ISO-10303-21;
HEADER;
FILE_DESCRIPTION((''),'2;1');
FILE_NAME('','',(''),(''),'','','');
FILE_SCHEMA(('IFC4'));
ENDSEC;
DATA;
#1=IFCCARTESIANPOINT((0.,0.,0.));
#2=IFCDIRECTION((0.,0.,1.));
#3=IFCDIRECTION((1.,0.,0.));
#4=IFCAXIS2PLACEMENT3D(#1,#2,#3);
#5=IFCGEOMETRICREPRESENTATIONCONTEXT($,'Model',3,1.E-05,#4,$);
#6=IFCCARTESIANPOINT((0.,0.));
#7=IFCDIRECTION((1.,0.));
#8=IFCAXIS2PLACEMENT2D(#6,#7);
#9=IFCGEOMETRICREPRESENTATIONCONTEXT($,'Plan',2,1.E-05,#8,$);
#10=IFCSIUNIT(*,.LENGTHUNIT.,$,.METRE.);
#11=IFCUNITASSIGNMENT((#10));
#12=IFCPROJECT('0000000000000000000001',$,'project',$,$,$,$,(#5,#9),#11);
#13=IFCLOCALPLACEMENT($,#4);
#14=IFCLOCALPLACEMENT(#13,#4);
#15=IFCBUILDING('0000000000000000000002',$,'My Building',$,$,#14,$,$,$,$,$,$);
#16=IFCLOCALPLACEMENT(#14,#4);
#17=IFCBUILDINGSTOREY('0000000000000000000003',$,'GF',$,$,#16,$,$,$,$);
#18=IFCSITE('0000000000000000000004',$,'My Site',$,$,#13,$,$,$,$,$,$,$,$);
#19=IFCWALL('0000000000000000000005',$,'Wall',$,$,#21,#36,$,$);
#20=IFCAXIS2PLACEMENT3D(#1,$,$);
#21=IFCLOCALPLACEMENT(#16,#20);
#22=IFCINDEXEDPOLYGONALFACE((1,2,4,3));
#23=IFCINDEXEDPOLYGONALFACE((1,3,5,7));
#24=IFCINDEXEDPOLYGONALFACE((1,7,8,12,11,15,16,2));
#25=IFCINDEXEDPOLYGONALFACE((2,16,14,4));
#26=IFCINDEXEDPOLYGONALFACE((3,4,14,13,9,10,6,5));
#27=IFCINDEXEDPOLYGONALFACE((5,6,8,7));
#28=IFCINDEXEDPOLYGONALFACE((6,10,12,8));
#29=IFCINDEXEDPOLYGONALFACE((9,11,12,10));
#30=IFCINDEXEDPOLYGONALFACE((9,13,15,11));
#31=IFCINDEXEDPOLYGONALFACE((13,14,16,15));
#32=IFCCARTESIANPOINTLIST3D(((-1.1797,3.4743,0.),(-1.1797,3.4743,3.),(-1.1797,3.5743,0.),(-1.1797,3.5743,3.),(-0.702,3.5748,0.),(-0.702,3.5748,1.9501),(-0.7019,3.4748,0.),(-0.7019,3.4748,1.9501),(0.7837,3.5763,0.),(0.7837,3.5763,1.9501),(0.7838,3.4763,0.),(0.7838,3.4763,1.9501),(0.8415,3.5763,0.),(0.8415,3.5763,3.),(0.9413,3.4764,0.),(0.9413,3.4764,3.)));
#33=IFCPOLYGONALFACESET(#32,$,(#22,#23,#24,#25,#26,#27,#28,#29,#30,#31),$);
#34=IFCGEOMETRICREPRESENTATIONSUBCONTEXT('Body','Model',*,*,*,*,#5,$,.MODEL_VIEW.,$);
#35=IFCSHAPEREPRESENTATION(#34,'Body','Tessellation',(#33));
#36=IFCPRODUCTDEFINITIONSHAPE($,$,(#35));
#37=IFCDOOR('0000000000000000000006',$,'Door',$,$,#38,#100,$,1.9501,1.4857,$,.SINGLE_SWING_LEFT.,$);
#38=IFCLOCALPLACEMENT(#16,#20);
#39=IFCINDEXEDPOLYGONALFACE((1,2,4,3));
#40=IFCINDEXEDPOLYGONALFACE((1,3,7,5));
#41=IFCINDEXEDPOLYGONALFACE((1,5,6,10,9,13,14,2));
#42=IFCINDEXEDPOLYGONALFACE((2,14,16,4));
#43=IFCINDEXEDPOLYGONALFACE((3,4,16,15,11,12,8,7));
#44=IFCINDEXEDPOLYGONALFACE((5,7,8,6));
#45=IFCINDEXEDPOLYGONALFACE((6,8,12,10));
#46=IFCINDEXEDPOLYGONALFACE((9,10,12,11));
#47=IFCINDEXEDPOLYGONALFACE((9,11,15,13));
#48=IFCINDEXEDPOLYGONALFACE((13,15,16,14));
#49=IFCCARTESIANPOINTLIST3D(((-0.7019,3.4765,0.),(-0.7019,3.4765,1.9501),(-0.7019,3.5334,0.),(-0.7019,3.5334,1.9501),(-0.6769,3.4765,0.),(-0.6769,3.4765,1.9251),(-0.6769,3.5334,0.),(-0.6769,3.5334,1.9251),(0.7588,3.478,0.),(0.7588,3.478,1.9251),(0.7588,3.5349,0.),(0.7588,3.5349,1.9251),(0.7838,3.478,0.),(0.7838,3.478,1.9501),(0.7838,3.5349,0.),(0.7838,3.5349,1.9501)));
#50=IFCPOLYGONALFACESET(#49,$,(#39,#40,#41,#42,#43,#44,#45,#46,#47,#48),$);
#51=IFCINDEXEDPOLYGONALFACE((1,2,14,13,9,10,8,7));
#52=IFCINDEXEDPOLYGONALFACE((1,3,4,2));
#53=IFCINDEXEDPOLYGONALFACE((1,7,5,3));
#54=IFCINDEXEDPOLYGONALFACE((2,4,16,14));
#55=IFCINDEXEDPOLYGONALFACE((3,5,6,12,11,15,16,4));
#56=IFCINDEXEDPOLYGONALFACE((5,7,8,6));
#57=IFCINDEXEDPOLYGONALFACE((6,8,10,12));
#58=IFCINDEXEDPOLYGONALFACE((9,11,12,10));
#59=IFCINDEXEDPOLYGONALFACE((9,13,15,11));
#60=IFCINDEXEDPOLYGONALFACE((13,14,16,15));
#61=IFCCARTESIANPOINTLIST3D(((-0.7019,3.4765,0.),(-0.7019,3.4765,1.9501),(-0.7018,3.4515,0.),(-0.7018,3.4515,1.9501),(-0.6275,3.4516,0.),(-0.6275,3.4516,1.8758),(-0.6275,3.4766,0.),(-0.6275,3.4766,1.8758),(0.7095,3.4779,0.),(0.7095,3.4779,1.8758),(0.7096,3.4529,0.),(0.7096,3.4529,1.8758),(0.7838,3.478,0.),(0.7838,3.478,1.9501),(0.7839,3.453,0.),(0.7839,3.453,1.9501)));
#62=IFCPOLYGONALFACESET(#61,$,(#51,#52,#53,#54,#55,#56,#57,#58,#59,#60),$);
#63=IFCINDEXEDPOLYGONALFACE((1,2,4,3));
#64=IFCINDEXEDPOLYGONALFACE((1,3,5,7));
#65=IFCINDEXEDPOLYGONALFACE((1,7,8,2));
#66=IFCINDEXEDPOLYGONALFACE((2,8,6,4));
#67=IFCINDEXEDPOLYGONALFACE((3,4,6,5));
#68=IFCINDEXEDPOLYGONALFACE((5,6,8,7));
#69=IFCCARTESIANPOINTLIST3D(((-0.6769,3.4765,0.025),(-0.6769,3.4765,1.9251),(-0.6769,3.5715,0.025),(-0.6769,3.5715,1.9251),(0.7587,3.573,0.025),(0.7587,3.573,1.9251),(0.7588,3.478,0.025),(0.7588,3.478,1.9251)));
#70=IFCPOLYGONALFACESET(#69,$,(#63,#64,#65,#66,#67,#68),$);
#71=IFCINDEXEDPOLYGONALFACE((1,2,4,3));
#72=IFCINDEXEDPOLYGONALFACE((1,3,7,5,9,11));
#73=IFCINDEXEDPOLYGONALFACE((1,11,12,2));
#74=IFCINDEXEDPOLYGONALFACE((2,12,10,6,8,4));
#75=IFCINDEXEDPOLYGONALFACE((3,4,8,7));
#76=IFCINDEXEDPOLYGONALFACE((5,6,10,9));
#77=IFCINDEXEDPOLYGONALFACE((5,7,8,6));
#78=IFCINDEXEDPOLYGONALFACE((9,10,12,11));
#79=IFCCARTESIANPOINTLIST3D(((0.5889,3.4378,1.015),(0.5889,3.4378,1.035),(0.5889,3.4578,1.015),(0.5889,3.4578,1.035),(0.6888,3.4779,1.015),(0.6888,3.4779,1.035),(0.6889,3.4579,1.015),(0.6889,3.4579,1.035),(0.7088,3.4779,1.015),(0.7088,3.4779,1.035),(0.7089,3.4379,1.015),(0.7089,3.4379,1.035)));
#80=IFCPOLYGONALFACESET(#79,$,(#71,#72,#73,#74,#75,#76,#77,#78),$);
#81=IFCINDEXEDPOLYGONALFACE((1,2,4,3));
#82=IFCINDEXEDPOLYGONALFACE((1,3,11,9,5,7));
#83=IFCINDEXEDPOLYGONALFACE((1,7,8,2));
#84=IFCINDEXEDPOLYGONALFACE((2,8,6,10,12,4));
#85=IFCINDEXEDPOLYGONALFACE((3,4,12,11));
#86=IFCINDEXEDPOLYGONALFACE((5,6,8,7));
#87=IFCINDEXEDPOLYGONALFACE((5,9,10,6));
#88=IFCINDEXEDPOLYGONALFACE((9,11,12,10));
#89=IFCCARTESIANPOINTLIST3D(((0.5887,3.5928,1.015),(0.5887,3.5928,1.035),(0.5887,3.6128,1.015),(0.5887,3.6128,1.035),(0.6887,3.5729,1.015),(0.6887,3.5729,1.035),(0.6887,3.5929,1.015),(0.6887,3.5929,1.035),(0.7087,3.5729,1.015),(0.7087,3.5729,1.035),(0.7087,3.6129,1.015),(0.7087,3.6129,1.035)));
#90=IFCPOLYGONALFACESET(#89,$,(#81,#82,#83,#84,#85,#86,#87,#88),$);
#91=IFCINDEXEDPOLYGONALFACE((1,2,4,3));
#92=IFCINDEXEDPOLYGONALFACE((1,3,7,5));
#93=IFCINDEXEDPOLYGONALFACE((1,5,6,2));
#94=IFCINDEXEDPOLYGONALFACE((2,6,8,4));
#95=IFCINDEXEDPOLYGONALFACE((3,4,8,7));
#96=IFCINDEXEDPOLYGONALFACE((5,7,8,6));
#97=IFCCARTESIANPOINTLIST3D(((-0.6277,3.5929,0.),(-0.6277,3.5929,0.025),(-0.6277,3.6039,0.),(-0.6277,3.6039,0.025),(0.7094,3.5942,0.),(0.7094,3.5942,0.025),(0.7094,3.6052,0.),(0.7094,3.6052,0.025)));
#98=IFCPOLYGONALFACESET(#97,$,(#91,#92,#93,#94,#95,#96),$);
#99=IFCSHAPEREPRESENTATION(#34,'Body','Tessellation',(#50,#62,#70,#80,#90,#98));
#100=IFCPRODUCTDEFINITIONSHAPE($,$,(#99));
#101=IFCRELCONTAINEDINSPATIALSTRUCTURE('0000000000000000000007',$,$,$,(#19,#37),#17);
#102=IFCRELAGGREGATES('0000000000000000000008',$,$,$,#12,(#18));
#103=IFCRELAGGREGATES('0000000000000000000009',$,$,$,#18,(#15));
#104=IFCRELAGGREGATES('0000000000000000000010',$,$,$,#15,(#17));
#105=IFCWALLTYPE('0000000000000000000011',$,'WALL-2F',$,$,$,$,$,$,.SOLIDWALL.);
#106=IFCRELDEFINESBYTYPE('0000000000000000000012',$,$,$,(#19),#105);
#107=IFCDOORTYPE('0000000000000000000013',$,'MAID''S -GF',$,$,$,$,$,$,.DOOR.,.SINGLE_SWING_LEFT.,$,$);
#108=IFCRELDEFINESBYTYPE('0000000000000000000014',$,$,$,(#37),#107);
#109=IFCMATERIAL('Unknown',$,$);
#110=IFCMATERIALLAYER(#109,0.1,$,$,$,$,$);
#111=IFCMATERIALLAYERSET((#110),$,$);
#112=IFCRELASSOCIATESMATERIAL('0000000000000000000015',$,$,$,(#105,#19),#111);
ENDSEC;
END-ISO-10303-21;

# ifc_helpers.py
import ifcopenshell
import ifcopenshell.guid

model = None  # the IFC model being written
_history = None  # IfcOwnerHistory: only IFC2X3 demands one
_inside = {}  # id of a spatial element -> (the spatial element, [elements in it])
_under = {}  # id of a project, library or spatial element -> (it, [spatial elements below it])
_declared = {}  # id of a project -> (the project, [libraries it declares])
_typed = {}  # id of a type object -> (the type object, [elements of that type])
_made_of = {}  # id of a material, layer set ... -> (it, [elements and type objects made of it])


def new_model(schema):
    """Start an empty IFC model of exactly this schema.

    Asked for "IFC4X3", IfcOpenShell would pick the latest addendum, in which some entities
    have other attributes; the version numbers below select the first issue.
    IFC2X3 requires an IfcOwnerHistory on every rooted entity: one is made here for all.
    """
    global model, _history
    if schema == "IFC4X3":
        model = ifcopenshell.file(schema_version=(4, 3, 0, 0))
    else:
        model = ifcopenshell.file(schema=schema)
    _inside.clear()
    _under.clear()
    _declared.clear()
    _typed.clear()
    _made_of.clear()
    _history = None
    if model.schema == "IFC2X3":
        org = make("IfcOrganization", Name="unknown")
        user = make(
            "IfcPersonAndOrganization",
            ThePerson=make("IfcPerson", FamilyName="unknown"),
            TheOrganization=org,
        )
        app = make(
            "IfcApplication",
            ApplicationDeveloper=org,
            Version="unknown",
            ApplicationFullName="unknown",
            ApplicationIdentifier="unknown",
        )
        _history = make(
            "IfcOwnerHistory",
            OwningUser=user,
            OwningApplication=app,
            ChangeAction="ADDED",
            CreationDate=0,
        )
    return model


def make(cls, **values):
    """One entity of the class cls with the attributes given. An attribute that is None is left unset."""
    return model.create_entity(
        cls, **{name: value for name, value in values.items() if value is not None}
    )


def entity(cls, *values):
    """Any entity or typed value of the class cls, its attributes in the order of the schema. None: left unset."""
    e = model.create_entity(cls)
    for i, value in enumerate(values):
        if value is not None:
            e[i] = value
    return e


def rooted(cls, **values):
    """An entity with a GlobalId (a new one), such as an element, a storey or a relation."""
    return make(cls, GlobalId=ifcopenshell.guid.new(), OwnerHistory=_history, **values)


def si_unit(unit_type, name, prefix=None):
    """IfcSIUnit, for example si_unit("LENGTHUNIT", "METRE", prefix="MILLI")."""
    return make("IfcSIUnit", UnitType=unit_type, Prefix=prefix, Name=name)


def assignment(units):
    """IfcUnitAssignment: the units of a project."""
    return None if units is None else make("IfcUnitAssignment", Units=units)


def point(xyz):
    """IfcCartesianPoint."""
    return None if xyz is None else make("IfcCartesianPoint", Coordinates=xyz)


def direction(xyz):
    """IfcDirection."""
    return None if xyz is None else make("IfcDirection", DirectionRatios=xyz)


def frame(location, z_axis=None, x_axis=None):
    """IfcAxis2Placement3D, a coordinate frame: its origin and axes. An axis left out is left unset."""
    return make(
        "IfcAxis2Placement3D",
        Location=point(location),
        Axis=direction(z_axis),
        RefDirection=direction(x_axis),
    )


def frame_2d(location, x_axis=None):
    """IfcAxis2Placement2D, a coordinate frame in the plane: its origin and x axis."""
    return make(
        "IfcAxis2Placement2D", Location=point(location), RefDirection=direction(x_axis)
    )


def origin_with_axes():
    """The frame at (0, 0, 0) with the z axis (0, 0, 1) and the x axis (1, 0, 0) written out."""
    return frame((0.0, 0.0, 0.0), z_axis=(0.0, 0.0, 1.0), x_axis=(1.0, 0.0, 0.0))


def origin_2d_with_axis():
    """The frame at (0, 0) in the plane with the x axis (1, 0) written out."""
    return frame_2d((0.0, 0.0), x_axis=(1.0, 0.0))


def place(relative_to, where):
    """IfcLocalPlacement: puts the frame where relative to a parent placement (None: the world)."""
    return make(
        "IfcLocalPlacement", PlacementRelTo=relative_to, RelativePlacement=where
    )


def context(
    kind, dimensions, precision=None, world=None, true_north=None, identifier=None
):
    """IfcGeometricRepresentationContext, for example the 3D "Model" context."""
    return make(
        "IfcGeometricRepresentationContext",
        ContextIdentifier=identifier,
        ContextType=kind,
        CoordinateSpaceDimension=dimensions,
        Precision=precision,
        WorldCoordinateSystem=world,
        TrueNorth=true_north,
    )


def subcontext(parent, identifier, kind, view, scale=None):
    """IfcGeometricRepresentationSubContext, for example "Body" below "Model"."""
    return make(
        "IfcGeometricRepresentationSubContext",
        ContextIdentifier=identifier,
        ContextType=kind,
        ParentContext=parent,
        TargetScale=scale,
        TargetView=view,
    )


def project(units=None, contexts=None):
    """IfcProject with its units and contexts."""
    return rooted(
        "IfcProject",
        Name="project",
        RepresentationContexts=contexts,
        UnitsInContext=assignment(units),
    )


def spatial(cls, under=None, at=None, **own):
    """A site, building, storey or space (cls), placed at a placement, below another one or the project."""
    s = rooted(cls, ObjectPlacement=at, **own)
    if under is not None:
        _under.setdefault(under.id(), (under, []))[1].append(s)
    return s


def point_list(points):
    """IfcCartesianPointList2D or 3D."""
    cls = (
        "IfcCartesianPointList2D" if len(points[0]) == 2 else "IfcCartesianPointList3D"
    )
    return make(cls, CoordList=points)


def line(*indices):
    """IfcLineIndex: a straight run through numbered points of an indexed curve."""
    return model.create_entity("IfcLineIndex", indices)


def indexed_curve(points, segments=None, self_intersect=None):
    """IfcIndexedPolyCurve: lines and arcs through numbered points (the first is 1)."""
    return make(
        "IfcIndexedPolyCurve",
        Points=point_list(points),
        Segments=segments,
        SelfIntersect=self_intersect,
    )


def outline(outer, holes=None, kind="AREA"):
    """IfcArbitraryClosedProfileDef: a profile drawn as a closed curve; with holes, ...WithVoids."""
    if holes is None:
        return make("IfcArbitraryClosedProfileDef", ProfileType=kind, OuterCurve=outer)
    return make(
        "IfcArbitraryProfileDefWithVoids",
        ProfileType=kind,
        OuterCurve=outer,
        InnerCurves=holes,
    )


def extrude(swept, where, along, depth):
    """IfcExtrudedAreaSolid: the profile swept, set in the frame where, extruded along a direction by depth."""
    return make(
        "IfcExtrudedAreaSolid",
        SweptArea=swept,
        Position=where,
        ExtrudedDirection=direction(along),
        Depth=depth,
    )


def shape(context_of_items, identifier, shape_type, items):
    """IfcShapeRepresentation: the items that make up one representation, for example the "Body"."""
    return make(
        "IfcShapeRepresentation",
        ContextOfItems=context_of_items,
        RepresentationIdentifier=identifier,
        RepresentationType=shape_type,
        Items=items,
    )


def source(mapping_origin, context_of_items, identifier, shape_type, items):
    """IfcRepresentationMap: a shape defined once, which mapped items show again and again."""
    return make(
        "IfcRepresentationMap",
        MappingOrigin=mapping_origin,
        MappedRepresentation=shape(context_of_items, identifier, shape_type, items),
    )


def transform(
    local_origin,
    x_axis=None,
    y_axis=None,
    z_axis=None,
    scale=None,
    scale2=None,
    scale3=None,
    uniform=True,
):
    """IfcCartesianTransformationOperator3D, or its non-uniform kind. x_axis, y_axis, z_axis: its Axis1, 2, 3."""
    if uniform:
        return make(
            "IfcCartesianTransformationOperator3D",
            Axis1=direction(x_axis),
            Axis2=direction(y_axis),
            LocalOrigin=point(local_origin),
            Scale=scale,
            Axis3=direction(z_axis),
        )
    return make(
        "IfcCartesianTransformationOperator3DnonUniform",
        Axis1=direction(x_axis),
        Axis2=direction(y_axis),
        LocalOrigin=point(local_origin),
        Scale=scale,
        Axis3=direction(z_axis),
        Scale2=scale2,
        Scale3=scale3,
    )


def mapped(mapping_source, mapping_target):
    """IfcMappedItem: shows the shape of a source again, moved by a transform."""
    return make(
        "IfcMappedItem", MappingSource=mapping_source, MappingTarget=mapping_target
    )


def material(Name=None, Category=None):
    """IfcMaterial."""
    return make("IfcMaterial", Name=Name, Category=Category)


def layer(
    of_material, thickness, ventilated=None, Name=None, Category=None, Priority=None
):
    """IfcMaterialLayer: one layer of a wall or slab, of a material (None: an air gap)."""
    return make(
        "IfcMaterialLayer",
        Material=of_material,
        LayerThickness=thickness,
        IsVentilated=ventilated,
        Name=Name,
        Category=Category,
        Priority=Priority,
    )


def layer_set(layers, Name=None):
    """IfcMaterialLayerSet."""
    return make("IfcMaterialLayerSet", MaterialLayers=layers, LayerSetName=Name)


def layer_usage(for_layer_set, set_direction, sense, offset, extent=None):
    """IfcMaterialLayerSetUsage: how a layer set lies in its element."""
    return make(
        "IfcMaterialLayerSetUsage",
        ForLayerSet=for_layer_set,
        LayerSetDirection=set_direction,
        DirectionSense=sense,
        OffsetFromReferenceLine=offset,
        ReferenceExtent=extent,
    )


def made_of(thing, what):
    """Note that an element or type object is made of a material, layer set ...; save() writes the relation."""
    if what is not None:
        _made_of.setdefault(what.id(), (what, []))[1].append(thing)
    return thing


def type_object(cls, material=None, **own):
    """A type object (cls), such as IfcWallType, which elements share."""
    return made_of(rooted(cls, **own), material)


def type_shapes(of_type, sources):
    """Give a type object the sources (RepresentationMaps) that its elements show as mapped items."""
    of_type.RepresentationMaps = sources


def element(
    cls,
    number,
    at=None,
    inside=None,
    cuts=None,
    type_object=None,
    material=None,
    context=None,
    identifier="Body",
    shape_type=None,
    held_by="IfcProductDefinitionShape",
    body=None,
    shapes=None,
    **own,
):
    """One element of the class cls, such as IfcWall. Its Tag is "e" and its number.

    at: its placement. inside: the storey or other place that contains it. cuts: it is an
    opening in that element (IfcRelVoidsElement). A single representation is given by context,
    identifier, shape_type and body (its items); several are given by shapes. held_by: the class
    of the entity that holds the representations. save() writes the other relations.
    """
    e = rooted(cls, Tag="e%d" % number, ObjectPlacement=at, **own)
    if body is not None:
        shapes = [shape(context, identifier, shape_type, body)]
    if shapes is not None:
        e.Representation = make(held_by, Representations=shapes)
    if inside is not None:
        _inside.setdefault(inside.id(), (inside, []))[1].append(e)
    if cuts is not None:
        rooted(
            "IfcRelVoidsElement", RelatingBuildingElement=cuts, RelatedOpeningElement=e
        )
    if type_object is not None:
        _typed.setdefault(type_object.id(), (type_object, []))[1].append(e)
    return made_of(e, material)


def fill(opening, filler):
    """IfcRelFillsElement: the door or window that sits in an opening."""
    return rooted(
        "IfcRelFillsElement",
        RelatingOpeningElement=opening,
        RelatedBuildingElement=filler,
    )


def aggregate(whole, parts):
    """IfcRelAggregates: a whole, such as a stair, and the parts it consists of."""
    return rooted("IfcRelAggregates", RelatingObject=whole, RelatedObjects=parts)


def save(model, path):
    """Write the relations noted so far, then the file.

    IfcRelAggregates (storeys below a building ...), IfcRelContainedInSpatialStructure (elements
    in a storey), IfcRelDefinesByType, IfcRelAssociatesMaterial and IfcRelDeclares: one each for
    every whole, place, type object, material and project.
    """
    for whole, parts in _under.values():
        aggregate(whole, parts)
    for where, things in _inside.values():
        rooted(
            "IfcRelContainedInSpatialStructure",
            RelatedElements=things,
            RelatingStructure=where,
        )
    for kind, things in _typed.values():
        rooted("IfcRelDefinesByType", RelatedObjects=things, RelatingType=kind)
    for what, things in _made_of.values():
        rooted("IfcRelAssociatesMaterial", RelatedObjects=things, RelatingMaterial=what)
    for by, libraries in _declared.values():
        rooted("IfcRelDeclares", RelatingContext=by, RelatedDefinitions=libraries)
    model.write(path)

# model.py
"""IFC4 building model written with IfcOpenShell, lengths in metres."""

from ifc_helpers import new_model, entity, si_unit, frame, origin_with_axes, origin_2d_with_axis, place, context, subcontext, project, spatial, line, indexed_curve, outline, extrude, shape, source, transform, mapped, material, layer, layer_set, layer_usage, type_object, type_shapes, element, fill, save


model = new_model("IFC4")

# Units and contexts
model_context = context("Model", 3, precision=1e-05, world=origin_with_axes())
plan_context = context("Plan", 2, precision=1e-05, world=origin_2d_with_axis())
body_context_1 = subcontext(model_context, "Body", "Model", "MODEL_VIEW")
body_context_2 = subcontext(plan_context, "Body", "Plan", "PLAN_VIEW")
ifc_project = project(units=[si_unit("LENGTHUNIT", "METRE")], contexts=[model_context, plan_context])

# Site, building, storey
site_placement = place(None, origin_with_axes())
site = spatial("IfcSite", under=ifc_project, at=site_placement, Name="My Site")
building_placement = place(site_placement, origin_with_axes())
building = spatial("IfcBuilding", under=site, at=building_placement, Name="My Building")
storey_placement = place(building_placement, origin_with_axes())
storey = spatial("IfcBuildingStorey", under=building, at=storey_placement, Name="GF")

# Shared definitions
ifc_material = material(Name="Unknown")

# Shared definitions
ifc_layer_1 = layer(ifc_material, 0.1)
ifc_layer_set_1 = layer_set([ifc_layer_1])
wall_type_1 = type_object("IfcWallType", Name="WALL-2F", PredefinedType="SOLIDWALL", material=ifc_layer_set_1)

# Wall, opening, door
ifc_layer_usage_1 = layer_usage(ifc_layer_set_1, "AXIS2", "POSITIVE", 0.0)
wall_1_placement = place(storey_placement, frame((0.8415, 3.5763, 0.0), z_axis=(0.0, 0.0, 1.0), x_axis=(-1.0, -0.000997, 0.0)))
wall_1 = element("IfcWall", 1, at=wall_1_placement, inside=storey, type_object=wall_type_1, material=ifc_layer_usage_1, Name="Wall", context=body_context_1, shape_type="SweptSolid", body=[
    extrude(outline(indexed_curve([(0.0, 0.0), (-0.0997, 0.1), (2.0213, 0.1), (2.0212, 0.0)], segments=[line(1, 2, 3, 4, 1)])), origin_with_axes(), (0.0, 0.0, 1.0), 3.0),
])
shared_shape_1 = source(origin_with_axes(), body_context_1, "Body", "SweptSolid", [
    extrude(outline(indexed_curve([(0.0, 0.0), (1.4857, 0.0), (1.4857, 1.9501), (0.0, 1.9501)], segments=[line(1, 2, 3, 4, 1)])), frame((0.0, -0.6, 0.0), z_axis=(0.0, -1.0, 0.0), x_axis=(1.0, 0.0, 0.0)), (0.0, 0.0, -1.0), 1.2),
])
opening_1_placement = place(wall_1_placement, frame((1.5436, 0.19, 0.0), z_axis=(0.0, 0.0, 1.0), x_axis=(-1.0, 0.000001, 0.0)))
opening_1 = element("IfcOpeningElement", 2, at=opening_1_placement, cuts=wall_1, PredefinedType="OPENING", context=body_context_1, shape_type="MappedRepresentation", body=[
    mapped(shared_shape_1, transform((0.0, 0.0, 0.0), x_axis=(1.0, 0.0, 0.0), y_axis=(0.0, 1.0, 0.0), z_axis=(0.0, 0.0, 1.0), scale=1.0)),
])
door_type_1 = type_object("IfcDoorType", Name="MAID'S -GF", OperationType="SINGLE_SWING_LEFT", PredefinedType="DOOR")
shared_shape_2 = source(origin_with_axes(), body_context_1, "Body", "SweptSolid", [
    extrude(outline(indexed_curve([(0.0, 0.0), (0.0, 1.9501), (1.4857, 1.9501), (1.4857, 0.0), (1.4607, 0.0), (1.4607, 1.9251), (0.025, 1.9251), (0.025, 0.0)], segments=[line(1, 2, 3, 4, 5, 6, 7, 8, 1)])), frame((0.0, 0.0093, 0.0), z_axis=(0.0, -1.0, 0.0), x_axis=(1.0, 0.0, 0.0)), (0.0, 0.0, -1.0), 0.0569),
    extrude(outline(indexed_curve([(0.0, 0.0), (0.0, 1.9501), (1.4857, 1.9501), (1.4857, 0.0), (1.4114, 0.0), (1.4114, 1.8758), (0.0743, 1.8758), (0.0743, 0.0)], segments=[line(1, 2, 3, 4, 5, 6, 7, 8, 1)])), frame((0.0, -0.0157, 0.0), z_axis=(0.0, -1.0, 0.0), x_axis=(1.0, 0.0, 0.0)), (0.0, 0.0, -1.0), 0.025),
    extrude(outline(indexed_curve([(0.0, 0.0), (1.4357, 0.0), (1.4357, 0.095), (0.0, 0.095)], segments=[line(1, 2, 3, 4, 1)])), frame((0.025, 0.0093, 0.025), z_axis=(0.0, 0.0, 1.0), x_axis=(1.0, 0.0, 0.0)), (0.0, 0.0, 1.0), 1.9001),
    extrude(outline(indexed_curve([(0.0, 0.0), (0.0, -0.04), (-0.12, -0.04), (-0.12, -0.02), (-0.02, -0.02), (-0.02, 0.0)], segments=[line(1, 2, 3, 4, 5, 6, 1)])), frame((1.4107, 0.0093, 1.015), z_axis=(0.0, 0.0, 1.0), x_axis=(1.0, 0.0, 0.0)), (0.0, 0.0, 1.0), 0.02),
    extrude(outline(indexed_curve([(0.0, 0.0), (0.0, 0.04), (-0.12, 0.04), (-0.12, 0.02), (-0.02, 0.02), (-0.02, 0.0)], segments=[line(1, 2, 3, 4, 5, 6, 1)])), frame((1.4107, 0.1043, 1.015), z_axis=(0.0, 0.0, 1.0), x_axis=(1.0, 0.0, 0.0)), (0.0, 0.0, 1.0), 0.02),
    extrude(outline(indexed_curve([(0.0, 0.0), (1.3371, 0.0), (1.3371, 0.011), (0.0, 0.011)], segments=[line(1, 2, 3, 4, 1)])), frame((0.0743, 0.1256, 0.0), z_axis=(0.0, 0.0, 1.0), x_axis=(1.0, 0.0, 0.0)), (0.0, 0.0, 1.0), 0.025),
])
shared_shape_3 = source(origin_with_axes(), body_context_2, "Body", "Curve2D", [
    entity("IfcIndexedPolyCurve", entity("IfcCartesianPointList2D", [[0.0, -0.0157], [0.0, 0.0662], [0.025, 0.0662], [0.025, 0.0093], [0.0743, 0.0093], [0.0743, -0.0157]]), [entity("IfcLineIndex", [1, 2, 3, 4, 5, 6, 1])]),
    entity("IfcIndexedPolyCurve", entity("IfcCartesianPointList2D", [[1.4857, -0.0157], [1.4857, 0.0662], [1.4607, 0.0662], [1.4607, 0.0093], [1.4114, 0.0093], [1.4114, -0.0157]]), [entity("IfcLineIndex", [1, 2, 3, 4, 5, 6, 1])]),
    entity("IfcTrimmedCurve", entity("IfcEllipse", entity("IfcAxis2Placement2D", entity("IfcCartesianPoint", [0.12, 0.0662]), entity("IfcDirection", [1.0, 0.0])), 1.3407, 1.4357), [entity("IfcCartesianPoint", [1.4607, 0.0662])], [entity("IfcCartesianPoint", [0.12, 1.5019])], True, "CARTESIAN"),
    entity("IfcIndexedPolyCurve", entity("IfcCartesianPointList2D", [[0.025, 0.0662], [0.12, 0.0662], [0.12, 1.5019], [0.025, 1.5019]]), [entity("IfcLineIndex", [1, 2, 3, 4, 1])]),
])
type_shapes(door_type_1, [shared_shape_2, shared_shape_3])
door_1_placement = place(opening_1_placement, frame((0.0001, 0.0824, 0.0), z_axis=(0.0, 0.0, 1.0), x_axis=(1.0, 0.0, 0.0)))
door_1 = element("IfcDoor", 3, at=door_1_placement, inside=storey, type_object=door_type_1, Name="Door", OperationType="SINGLE_SWING_LEFT", OverallHeight=1.9501, OverallWidth=1.4857, shapes=[
    shape(body_context_1, "Body", "MappedRepresentation", [mapped(shared_shape_2, transform((0.0, 0.0, 0.0), x_axis=(1.0, 0.0, 0.0), y_axis=(0.0, 1.0, 0.0), z_axis=(0.0, 0.0, 1.0), scale=1.0))]),
    shape(body_context_2, "Body", "MappedRepresentation", [mapped(shared_shape_3, transform((0.0, 0.0, 0.0), x_axis=(1.0, 0.0, 0.0), y_axis=(0.0, 1.0, 0.0), z_axis=(0.0, 0.0, 1.0), scale=1.0))]),
])
fill(opening_1, door_1)

save(model, "model.ifc")
